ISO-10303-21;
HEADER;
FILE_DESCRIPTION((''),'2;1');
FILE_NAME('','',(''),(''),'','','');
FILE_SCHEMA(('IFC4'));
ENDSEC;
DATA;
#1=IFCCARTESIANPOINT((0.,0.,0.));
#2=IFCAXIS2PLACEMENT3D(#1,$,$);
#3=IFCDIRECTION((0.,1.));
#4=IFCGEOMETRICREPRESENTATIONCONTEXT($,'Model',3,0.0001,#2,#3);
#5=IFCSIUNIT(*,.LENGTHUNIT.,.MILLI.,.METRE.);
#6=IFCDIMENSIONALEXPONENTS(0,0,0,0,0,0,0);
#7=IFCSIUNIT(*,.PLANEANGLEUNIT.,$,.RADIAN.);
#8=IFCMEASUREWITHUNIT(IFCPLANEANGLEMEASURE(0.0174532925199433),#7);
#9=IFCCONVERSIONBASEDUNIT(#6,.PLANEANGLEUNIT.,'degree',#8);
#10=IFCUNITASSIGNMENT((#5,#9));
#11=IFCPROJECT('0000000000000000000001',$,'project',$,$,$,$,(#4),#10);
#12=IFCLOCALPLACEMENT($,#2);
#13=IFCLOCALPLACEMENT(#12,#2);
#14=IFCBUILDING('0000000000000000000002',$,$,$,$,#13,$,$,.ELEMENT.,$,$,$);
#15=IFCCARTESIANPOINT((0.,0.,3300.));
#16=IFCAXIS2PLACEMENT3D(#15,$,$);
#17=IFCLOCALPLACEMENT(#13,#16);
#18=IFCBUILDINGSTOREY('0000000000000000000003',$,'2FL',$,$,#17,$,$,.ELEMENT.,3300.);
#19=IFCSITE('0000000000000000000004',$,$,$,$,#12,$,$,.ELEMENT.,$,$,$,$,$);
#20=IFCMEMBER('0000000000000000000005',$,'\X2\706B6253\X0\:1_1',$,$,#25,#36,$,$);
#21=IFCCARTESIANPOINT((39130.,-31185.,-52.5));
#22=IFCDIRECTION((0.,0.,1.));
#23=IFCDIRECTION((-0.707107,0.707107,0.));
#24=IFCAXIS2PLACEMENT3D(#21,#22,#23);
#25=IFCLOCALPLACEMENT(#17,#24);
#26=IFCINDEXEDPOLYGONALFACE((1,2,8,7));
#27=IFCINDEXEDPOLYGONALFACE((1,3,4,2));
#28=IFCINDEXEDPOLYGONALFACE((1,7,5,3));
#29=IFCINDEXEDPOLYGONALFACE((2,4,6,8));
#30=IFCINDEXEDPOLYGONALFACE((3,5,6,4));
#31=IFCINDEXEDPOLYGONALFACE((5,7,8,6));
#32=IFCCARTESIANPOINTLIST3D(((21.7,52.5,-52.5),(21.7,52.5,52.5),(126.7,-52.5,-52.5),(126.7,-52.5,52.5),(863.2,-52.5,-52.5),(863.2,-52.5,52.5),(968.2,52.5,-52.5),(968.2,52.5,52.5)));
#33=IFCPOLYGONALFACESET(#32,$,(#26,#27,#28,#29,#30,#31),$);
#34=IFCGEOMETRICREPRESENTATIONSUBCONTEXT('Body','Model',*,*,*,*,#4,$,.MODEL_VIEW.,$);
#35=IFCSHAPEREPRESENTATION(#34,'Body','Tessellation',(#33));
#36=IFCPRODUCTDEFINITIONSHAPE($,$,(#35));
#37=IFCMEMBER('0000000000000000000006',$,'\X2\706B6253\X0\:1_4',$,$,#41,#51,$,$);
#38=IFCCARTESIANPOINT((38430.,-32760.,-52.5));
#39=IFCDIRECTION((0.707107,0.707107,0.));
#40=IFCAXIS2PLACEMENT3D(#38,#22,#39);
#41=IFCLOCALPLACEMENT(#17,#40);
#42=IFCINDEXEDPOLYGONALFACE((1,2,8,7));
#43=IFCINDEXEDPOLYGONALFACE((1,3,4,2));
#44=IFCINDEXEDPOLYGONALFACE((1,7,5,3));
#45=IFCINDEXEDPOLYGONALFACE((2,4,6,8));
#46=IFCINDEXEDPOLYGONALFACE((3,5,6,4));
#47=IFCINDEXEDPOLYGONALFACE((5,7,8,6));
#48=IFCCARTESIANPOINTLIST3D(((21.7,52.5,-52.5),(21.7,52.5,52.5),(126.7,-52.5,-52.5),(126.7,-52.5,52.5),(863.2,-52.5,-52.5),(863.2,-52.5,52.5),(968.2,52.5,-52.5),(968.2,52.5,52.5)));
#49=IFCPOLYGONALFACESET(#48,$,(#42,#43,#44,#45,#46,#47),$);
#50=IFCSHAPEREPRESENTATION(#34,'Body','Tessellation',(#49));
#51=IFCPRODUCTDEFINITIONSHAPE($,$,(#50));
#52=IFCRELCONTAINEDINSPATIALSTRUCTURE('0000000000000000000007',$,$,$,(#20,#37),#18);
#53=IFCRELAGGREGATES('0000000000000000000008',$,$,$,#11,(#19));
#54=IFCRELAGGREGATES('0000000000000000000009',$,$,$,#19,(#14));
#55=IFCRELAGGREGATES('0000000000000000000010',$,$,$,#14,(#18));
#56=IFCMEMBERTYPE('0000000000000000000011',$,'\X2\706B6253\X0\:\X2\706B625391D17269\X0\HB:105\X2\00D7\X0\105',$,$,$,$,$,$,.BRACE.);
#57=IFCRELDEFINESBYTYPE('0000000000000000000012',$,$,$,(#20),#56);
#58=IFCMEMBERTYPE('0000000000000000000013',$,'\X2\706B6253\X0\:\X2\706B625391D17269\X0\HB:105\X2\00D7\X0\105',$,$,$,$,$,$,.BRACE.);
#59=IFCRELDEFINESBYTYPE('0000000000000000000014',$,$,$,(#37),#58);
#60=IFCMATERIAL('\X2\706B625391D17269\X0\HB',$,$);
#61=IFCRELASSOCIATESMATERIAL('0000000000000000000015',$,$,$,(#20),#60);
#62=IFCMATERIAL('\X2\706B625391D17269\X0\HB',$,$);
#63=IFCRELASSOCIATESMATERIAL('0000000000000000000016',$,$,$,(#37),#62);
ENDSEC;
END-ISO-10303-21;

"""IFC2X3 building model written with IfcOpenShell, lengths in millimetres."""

from ifc_helpers import new_model, entity, si_unit, converted_unit, direction, frame, origin, place, context, subcontext, project, spatial, polyline, outline, extrude, material, type_object, element, save


model = new_model("IFC2X3")

# Units and contexts
model_context = context("Model", 3, precision=0.0001, world=origin(), true_north=direction((0.0, 1.0)))
body_context = subcontext(model_context, "Body", "Model", "MODEL_VIEW")
ifc_project = project(units=[si_unit("LENGTHUNIT", "METRE", prefix="MILLI"), converted_unit("PLANEANGLEUNIT", "degree", entity("IfcPlaneAngleMeasure", 0.0174532925199433), si_unit("PLANEANGLEUNIT", "RADIAN"), dimensions=[0, 0, 0, 0, 0, 0, 0])], contexts=[model_context])

# Site, building, storey
site_placement = place(None, origin())
site = spatial("IfcSite", under=ifc_project, at=site_placement, CompositionType="ELEMENT")
building_placement = place(site_placement, origin())
building = spatial("IfcBuilding", under=site, at=building_placement, CompositionType="ELEMENT")
storey_placement = place(building_placement, frame((0.0, 0.0, 3300.0)))
storey = spatial("IfcBuildingStorey", under=building, at=storey_placement, Name="2FL", CompositionType="ELEMENT", Elevation=3300.0)

# Members
ifc_material_1 = material(Name="火打金物HB")
member_type_1 = type_object("IfcMemberType", Name="火打:火打金物HB:105×105", PredefinedType="BRACE")
member_1_placement = place(storey_placement, frame((39130.0, -31185.0, -52.5), z_axis=(0.0, 0.0, 1.0), x_axis=(-0.707107, 0.707107, 0.0)))
element("IfcMember", 1, at=member_1_placement, inside=storey, type_object=member_type_1, material=ifc_material_1, Name="火打:1_1", context=body_context, shape_type="SweptSolid", body=[
    extrude(outline(polyline([(126.7, -52.5, 0.0), (21.7, 52.5, 0.0), (968.2, 52.5, 0.0), (863.2, -52.5, 0.0), (126.7, -52.5, 0.0)])), frame((0.0, 0.0, -52.5), z_axis=(0.0, 0.0, 1.0), x_axis=(1.0, 0.0, 0.0)), (0.0, 0.0, 1.0), 105.0),
])
ifc_material_2 = material(Name="火打金物HB")
member_type_2 = type_object("IfcMemberType", Name="火打:火打金物HB:105×105", PredefinedType="BRACE")
member_2_placement = place(storey_placement, frame((38430.0, -32760.0, -52.5), z_axis=(0.0, 0.0, 1.0), x_axis=(0.707107, 0.707107, 0.0)))
element("IfcMember", 2, at=member_2_placement, inside=storey, type_object=member_type_2, material=ifc_material_2, Name="火打:1_4", context=body_context, shape_type="SweptSolid", body=[
    extrude(outline(polyline([(126.7, -52.5, 0.0), (21.7, 52.5, 0.0), (968.2, 52.5, 0.0), (863.2, -52.5, 0.0), (126.7, -52.5, 0.0)])), frame((0.0, 0.0, -52.5), z_axis=(0.0, 0.0, 1.0), x_axis=(1.0, 0.0, 0.0)), (0.0, 0.0, 1.0), 105.0),
])

save(model, "model.ifc")
